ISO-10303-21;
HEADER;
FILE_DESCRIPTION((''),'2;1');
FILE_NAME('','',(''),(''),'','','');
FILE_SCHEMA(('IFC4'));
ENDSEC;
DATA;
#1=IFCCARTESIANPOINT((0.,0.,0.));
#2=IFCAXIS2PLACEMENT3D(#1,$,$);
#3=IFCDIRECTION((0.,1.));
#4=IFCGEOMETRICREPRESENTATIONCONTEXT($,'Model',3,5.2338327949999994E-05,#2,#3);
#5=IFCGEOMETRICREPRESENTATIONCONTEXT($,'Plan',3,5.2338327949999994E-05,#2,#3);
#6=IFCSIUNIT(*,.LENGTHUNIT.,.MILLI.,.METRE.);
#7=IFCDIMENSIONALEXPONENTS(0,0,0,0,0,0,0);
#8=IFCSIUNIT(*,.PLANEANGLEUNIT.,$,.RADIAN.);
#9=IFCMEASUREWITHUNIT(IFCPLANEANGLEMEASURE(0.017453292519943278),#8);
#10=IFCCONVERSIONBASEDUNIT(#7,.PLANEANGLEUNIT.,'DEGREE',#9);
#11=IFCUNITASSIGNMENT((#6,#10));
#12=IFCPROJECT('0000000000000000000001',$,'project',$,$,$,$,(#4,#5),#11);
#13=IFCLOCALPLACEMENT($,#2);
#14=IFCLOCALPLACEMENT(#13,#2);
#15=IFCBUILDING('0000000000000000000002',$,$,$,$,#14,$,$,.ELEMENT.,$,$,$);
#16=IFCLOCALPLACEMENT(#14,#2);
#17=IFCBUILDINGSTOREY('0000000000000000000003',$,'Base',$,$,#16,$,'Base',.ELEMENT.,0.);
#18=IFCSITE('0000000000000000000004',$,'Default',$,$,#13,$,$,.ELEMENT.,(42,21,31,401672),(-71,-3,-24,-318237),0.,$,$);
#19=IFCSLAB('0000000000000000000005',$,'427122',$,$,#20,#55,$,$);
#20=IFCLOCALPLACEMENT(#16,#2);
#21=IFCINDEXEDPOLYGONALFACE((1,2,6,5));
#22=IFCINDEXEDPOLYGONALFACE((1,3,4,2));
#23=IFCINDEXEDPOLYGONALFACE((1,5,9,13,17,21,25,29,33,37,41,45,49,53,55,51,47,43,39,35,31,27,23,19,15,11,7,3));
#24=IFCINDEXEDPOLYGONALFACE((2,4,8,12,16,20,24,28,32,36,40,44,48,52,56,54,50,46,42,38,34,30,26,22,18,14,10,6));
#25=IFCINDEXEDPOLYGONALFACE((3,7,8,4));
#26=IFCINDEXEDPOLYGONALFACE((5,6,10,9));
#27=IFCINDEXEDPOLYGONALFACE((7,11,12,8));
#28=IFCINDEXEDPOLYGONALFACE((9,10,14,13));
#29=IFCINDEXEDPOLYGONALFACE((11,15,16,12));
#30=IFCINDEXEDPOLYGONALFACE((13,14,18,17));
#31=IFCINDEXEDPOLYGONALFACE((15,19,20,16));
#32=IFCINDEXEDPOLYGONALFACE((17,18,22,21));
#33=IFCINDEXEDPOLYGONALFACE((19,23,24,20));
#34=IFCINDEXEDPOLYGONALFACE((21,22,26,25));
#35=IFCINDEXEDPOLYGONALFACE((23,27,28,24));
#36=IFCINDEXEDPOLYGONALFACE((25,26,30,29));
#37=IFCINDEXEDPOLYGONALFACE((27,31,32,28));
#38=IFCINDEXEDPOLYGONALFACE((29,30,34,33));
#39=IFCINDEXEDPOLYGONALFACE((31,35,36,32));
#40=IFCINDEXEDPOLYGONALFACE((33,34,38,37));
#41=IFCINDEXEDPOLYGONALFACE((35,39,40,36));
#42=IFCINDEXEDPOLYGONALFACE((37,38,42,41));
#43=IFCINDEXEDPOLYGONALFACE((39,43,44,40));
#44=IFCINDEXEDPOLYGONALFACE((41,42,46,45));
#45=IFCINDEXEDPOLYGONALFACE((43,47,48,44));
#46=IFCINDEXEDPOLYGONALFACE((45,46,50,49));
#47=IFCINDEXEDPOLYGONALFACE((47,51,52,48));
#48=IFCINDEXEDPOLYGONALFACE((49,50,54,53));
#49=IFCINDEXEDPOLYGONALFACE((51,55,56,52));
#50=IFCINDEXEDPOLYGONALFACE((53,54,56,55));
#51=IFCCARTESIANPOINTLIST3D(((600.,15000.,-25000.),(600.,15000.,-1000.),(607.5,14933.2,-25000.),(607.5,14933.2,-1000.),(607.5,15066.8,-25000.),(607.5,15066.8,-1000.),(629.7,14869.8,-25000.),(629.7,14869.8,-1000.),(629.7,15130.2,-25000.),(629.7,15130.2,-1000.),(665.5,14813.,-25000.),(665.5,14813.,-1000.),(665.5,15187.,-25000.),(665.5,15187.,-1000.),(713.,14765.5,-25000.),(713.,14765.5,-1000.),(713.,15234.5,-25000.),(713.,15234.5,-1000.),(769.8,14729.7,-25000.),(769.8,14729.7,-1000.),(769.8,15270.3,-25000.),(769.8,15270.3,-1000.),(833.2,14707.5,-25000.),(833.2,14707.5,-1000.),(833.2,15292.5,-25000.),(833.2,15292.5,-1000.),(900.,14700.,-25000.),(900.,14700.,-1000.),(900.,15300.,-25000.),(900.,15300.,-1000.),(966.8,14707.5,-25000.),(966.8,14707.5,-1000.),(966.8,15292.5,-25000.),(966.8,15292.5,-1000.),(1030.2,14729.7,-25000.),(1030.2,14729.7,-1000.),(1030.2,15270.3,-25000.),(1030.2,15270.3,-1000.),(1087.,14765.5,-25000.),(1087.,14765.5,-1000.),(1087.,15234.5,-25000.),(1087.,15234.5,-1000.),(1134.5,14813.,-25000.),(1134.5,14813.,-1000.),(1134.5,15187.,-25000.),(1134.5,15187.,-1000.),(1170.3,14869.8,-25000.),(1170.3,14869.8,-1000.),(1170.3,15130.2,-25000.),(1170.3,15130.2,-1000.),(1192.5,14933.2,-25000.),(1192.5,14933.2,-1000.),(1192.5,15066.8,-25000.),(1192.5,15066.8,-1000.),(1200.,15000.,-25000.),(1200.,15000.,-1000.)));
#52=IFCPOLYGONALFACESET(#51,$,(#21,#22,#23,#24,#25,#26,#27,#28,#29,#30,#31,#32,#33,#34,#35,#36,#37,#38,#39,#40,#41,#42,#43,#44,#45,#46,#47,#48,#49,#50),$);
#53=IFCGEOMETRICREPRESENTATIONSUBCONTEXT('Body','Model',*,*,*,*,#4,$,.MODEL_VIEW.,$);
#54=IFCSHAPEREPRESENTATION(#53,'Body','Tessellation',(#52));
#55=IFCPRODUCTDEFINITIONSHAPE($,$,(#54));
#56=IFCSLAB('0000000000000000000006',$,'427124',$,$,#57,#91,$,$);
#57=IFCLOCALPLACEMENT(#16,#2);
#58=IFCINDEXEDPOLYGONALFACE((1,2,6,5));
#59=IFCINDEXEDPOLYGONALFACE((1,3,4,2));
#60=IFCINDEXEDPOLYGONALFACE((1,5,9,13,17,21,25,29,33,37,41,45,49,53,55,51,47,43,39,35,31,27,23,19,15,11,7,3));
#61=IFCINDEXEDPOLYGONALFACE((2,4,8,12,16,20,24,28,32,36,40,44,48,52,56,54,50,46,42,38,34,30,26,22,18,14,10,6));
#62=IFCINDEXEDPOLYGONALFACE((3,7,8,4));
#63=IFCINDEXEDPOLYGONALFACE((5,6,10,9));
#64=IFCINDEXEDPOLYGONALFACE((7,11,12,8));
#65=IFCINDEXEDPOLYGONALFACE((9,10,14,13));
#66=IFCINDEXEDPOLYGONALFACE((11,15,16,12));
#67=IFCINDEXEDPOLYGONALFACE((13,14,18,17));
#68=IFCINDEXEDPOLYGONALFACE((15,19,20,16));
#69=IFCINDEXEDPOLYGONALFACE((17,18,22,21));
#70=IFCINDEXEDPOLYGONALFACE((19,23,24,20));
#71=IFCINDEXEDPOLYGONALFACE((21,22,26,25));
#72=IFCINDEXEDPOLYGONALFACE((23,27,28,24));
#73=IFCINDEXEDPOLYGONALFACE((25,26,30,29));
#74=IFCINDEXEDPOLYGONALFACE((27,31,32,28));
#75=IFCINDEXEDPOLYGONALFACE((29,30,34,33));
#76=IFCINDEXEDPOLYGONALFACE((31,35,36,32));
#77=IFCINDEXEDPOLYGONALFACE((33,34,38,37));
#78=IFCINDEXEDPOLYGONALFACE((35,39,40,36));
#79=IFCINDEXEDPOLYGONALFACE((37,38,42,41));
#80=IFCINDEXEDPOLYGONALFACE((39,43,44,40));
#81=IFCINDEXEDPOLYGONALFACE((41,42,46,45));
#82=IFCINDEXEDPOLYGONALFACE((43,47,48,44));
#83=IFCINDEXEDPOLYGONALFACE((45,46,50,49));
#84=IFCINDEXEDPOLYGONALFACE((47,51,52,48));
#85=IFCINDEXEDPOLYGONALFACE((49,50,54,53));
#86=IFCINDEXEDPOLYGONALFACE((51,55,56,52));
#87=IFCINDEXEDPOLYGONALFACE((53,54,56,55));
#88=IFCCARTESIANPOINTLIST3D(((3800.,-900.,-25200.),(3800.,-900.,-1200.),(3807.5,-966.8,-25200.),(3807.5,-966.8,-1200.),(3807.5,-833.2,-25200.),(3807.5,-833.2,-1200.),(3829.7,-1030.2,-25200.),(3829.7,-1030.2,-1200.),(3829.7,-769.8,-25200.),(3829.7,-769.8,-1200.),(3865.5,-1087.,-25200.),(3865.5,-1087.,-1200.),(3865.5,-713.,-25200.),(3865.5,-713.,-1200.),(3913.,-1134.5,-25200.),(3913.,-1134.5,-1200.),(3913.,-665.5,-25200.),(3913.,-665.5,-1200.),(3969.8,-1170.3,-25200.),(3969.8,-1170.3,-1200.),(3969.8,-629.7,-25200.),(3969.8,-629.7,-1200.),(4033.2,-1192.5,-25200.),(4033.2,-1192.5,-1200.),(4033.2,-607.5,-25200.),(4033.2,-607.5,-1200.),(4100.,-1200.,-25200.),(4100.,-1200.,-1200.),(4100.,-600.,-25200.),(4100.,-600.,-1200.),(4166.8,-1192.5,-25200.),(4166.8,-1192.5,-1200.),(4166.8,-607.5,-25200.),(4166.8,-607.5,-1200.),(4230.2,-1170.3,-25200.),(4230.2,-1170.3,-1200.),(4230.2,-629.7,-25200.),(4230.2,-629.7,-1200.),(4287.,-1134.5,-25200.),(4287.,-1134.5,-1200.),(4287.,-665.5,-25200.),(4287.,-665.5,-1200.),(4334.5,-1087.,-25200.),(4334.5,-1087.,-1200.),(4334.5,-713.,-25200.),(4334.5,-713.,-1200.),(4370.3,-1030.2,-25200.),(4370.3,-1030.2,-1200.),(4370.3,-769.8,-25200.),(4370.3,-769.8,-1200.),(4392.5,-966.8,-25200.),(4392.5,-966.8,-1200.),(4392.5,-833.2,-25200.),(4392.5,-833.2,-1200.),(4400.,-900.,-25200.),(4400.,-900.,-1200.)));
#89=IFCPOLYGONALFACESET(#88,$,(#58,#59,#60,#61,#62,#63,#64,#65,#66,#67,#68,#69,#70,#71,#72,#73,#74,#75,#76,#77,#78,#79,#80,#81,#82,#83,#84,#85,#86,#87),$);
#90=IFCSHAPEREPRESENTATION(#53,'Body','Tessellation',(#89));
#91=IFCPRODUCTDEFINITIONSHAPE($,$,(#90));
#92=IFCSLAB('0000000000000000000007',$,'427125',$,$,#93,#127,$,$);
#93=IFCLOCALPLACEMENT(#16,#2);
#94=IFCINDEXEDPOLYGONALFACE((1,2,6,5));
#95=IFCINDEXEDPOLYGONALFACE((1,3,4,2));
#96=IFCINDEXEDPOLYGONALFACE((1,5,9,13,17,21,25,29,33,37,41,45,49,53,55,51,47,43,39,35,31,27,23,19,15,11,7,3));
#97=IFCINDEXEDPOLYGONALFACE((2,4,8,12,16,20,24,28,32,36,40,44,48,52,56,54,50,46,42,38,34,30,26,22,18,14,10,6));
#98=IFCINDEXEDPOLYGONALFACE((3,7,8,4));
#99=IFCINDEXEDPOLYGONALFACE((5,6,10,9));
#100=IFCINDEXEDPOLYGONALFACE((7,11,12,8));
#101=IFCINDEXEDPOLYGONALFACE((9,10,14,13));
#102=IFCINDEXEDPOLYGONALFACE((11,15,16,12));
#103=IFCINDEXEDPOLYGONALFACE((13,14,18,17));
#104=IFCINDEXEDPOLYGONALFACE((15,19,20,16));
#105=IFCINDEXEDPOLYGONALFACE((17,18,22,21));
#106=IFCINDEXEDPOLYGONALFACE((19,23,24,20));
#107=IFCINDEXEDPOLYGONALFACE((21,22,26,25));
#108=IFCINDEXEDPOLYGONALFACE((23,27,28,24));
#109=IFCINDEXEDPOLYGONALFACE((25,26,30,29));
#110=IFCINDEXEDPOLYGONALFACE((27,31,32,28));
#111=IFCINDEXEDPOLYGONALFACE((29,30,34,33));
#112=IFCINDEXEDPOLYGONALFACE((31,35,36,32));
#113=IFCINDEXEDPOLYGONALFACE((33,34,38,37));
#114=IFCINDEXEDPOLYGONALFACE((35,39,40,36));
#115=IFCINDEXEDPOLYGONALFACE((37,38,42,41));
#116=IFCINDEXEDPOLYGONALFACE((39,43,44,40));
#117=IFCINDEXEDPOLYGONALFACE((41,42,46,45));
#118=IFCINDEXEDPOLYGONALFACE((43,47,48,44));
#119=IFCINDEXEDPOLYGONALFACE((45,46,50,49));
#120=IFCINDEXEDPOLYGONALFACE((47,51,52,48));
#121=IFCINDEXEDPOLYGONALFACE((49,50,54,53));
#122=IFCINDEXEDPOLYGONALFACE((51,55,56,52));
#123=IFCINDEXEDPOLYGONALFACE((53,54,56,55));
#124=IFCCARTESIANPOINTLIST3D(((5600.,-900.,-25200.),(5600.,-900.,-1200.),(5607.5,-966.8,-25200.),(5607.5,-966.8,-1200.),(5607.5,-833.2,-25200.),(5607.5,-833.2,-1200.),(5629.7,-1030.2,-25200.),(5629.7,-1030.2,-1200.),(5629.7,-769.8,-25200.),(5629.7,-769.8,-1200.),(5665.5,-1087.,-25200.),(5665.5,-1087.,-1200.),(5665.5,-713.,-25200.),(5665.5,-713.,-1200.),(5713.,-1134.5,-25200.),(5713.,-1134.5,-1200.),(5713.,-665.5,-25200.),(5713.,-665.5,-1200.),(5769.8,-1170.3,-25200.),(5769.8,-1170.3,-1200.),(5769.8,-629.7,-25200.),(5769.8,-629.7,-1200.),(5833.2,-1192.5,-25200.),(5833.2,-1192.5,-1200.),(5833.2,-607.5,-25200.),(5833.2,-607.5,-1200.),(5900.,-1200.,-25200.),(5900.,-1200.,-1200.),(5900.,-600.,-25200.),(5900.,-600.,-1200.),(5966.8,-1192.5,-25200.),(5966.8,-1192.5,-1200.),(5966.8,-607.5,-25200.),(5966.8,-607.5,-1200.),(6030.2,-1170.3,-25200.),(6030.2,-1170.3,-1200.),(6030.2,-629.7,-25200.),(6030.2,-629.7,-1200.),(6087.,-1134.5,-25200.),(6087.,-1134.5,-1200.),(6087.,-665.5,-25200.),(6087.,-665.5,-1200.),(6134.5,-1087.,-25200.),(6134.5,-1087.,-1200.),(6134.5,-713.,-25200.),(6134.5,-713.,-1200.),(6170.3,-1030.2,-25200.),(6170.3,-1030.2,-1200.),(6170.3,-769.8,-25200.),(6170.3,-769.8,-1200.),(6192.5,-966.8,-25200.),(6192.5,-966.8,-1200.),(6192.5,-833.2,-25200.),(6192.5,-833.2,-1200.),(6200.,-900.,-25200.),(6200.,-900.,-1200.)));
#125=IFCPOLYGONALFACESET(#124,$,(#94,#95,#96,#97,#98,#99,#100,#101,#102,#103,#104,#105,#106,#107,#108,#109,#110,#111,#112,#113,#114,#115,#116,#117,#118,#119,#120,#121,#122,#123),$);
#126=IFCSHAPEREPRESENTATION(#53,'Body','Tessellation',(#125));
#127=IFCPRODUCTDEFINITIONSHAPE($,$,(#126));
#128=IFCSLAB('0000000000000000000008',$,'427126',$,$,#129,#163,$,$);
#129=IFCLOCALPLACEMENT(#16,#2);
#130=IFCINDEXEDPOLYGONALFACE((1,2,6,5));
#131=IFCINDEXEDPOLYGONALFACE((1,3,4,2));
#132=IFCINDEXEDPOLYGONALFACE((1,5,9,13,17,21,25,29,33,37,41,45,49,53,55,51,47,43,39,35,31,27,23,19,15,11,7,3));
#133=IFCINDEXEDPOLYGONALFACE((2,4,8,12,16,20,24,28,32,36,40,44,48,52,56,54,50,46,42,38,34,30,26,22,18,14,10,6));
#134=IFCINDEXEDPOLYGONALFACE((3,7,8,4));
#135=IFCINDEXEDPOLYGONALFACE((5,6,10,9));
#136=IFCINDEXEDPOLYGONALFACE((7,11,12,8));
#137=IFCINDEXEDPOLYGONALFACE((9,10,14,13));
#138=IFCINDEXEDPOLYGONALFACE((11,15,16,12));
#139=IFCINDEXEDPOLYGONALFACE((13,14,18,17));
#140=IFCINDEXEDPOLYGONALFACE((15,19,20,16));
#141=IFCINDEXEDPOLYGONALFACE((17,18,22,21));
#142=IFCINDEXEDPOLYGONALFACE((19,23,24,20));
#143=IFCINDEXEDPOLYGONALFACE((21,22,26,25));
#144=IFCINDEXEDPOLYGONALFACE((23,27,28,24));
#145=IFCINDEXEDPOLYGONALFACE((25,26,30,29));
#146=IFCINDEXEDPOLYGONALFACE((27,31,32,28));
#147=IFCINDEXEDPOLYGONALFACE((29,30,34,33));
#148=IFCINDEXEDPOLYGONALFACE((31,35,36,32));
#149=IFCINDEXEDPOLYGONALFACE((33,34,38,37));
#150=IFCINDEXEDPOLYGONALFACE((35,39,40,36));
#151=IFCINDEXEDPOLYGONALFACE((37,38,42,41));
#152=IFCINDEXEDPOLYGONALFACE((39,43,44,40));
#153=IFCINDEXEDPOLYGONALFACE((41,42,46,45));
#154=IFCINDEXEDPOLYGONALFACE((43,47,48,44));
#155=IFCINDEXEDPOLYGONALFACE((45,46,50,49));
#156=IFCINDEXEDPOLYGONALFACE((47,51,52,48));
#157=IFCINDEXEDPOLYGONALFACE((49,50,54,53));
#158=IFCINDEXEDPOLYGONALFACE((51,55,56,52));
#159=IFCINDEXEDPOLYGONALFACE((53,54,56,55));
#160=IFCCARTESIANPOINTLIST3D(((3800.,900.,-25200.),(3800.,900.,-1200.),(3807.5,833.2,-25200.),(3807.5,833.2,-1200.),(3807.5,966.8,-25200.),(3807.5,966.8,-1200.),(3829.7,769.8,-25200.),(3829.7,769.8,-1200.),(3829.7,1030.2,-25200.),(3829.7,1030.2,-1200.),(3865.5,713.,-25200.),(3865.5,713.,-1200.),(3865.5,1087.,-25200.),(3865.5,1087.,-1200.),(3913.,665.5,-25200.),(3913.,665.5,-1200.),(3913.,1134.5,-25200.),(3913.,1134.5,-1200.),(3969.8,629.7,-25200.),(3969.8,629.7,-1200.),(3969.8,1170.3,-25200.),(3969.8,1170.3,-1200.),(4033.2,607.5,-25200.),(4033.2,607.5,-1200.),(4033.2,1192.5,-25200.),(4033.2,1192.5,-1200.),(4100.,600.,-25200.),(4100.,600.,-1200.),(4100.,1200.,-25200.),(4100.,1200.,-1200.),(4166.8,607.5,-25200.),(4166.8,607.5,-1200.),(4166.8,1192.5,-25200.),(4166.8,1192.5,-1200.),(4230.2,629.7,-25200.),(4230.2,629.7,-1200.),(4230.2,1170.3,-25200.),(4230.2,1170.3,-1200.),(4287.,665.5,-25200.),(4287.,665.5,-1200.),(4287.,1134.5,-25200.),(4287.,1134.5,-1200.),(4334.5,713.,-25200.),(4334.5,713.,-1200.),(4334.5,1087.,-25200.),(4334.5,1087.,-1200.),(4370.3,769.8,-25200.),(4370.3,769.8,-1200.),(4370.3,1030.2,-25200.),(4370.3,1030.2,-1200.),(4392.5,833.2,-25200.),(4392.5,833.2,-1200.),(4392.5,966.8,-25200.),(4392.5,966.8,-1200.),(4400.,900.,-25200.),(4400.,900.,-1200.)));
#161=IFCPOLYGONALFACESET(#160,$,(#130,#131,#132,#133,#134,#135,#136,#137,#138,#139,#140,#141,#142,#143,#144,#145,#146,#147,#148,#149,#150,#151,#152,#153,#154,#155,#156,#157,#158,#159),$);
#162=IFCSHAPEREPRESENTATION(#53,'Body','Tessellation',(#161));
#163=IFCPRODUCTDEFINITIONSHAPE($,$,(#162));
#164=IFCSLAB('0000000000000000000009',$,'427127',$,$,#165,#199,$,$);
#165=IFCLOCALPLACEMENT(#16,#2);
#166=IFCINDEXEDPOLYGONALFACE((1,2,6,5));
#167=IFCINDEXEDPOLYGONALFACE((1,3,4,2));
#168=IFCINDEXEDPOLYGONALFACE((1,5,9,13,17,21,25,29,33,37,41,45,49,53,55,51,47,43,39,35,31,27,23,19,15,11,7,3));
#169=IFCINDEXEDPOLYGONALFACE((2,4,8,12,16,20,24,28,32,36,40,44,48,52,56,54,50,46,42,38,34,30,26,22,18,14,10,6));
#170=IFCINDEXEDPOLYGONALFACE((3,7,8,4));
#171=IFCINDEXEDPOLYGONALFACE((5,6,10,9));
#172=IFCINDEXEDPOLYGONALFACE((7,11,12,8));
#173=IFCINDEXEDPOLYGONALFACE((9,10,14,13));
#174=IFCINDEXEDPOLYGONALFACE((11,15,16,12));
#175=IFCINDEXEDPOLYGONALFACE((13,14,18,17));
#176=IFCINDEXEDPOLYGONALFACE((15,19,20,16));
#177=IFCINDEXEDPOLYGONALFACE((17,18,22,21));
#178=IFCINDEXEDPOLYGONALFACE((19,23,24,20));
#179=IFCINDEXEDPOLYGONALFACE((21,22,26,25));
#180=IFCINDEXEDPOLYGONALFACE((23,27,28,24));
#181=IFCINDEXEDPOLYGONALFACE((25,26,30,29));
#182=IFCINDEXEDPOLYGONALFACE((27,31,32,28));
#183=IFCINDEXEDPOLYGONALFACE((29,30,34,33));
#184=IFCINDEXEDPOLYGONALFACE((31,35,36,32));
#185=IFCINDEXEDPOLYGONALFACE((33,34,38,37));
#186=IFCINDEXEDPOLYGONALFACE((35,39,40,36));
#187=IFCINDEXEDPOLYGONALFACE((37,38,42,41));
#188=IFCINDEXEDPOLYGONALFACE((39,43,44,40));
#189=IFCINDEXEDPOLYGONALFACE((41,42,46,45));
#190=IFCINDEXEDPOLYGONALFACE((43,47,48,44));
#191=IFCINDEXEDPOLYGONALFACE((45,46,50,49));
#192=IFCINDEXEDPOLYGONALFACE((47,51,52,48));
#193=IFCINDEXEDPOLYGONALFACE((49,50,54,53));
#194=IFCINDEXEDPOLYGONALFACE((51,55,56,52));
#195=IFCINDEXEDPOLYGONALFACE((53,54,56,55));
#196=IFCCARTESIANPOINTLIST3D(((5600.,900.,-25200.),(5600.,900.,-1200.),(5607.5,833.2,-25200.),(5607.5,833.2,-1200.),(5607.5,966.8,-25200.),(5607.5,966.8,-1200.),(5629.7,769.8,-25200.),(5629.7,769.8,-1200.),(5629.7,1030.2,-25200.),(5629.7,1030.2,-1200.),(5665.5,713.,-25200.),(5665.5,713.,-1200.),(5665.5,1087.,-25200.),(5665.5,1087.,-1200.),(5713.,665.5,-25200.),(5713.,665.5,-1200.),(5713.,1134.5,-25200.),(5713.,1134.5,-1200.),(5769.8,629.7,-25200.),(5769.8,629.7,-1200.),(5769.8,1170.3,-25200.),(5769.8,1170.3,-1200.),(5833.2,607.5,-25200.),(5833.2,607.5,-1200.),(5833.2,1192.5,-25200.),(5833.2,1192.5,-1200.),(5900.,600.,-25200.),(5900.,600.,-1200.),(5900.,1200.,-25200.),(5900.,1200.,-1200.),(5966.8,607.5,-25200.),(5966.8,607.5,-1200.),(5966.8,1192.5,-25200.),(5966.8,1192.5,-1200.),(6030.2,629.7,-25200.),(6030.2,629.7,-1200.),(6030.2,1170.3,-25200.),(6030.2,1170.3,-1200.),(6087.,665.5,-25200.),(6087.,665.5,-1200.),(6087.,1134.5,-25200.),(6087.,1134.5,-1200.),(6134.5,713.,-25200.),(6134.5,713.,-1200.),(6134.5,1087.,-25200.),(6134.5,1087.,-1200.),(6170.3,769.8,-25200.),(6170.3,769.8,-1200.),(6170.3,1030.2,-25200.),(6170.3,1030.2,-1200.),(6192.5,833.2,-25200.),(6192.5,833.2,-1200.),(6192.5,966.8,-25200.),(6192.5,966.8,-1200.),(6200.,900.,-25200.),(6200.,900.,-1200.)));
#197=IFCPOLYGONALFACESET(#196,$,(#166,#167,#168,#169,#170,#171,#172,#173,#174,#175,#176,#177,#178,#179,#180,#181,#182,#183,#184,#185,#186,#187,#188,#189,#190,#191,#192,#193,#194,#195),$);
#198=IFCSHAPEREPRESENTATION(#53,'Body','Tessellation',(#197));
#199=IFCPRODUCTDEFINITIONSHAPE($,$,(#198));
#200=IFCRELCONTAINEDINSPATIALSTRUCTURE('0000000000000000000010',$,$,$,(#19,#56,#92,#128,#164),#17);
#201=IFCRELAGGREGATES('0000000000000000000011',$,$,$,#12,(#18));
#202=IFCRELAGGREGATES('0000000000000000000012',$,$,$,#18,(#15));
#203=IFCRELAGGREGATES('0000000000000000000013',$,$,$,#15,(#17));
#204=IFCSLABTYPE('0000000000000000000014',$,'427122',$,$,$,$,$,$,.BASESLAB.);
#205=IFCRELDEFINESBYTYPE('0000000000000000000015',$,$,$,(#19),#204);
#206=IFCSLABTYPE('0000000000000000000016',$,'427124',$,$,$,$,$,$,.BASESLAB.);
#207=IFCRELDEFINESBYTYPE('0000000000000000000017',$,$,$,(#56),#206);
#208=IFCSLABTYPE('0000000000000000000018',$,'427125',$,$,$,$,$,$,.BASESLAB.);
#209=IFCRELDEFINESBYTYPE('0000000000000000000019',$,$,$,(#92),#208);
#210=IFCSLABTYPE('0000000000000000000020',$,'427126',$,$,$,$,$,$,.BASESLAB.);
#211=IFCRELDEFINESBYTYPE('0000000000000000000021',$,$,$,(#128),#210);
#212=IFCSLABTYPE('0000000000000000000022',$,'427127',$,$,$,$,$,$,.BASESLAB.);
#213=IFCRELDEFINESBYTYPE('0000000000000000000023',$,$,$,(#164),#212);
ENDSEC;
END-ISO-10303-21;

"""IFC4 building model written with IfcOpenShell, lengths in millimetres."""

from ifc_helpers import new_model, entity, si_unit, converted_unit, direction, frame, origin, place, context, subcontext, project, spatial, arc, indexed_curve, outline, extrude, type_object, element, save


model = new_model("IFC4")

# Units and contexts
model_context = context("Model", 3, precision=5.2338327949999994e-05, world=origin(), true_north=direction((0.0, 1.0)))
plan_context = context("Plan", 3, precision=5.2338327949999994e-05, world=origin(), true_north=direction((0.0, 1.0)))
body_context = subcontext(model_context, "Body", "Model", "MODEL_VIEW")
ifc_project = project(units=[si_unit("LENGTHUNIT", "METRE", prefix="MILLI"), converted_unit("PLANEANGLEUNIT", "DEGREE", entity("IfcPlaneAngleMeasure", 0.017453292519943278), si_unit("PLANEANGLEUNIT", "RADIAN"), dimensions=[0, 0, 0, 0, 0, 0, 0])], contexts=[model_context, plan_context])

# Site, building, storey
site_placement = place(None, origin())
site = spatial("IfcSite", under=ifc_project, at=site_placement, Name="Default", CompositionType="ELEMENT", RefLatitude=(42, 21, 31, 401672), RefLongitude=(-71, -3, -24, -318237), RefElevation=0.0)
building_placement = place(site_placement, origin())
building = spatial("IfcBuilding", under=site, at=building_placement, CompositionType="ELEMENT")
storey_placement = place(building_placement, origin())
storey = spatial("IfcBuildingStorey", under=building, at=storey_placement, Name="Base", LongName="Base", CompositionType="ELEMENT", Elevation=0.0)

# Slabs
slab_type_1 = type_object("IfcSlabType", Name="427122", PredefinedType="BASESLAB")
slab_1_placement = place(storey_placement, origin())
element("IfcSlab", 1, at=slab_1_placement, inside=storey, type_object=slab_type_1, Name="427122", context=body_context, shape_type="SweptSolid", body=[
    extrude(outline(indexed_curve([(300.0, 0.0), (0.0, 300.0), (-300.0, 0.0), (0.0, -300.0)], segments=[arc(1, 2, 3), arc(3, 4, 1)], self_intersect=False)), frame((900.0, 15000.0, -25000.0)), (0.0, 0.0, 1.0), 24000.0),
])
slab_type_2 = type_object("IfcSlabType", Name="427124", PredefinedType="BASESLAB")
slab_2_placement = place(storey_placement, origin())
element("IfcSlab", 2, at=slab_2_placement, inside=storey, type_object=slab_type_2, Name="427124", context=body_context, shape_type="SweptSolid", body=[
    extrude(outline(indexed_curve([(300.0, 0.0), (0.0, 300.0), (-300.0, 0.0), (0.0, -300.0)], segments=[arc(1, 2, 3), arc(3, 4, 1)], self_intersect=False)), frame((4100.0, -900.0, -25200.0)), (0.0, 0.0, 1.0), 24000.0),
])
slab_type_3 = type_object("IfcSlabType", Name="427125", PredefinedType="BASESLAB")
slab_3_placement = place(storey_placement, origin())
element("IfcSlab", 3, at=slab_3_placement, inside=storey, type_object=slab_type_3, Name="427125", context=body_context, shape_type="SweptSolid", body=[
    extrude(outline(indexed_curve([(300.0, 0.0), (0.0, 300.0), (-300.0, 0.0), (0.0, -300.0)], segments=[arc(1, 2, 3), arc(3, 4, 1)], self_intersect=False)), frame((5900.0, -900.0, -25200.0)), (0.0, 0.0, 1.0), 24000.0),
])
slab_type_4 = type_object("IfcSlabType", Name="427126", PredefinedType="BASESLAB")
slab_4_placement = place(storey_placement, origin())
element("IfcSlab", 4, at=slab_4_placement, inside=storey, type_object=slab_type_4, Name="427126", context=body_context, shape_type="SweptSolid", body=[
    extrude(outline(indexed_curve([(300.0, 0.0), (0.0, 300.0), (-300.0, 0.0), (0.0, -300.0)], segments=[arc(1, 2, 3), arc(3, 4, 1)], self_intersect=False)), frame((4100.0, 900.0, -25200.0)), (0.0, 0.0, 1.0), 24000.0),
])
slab_type_5 = type_object("IfcSlabType", Name="427127", PredefinedType="BASESLAB")
slab_5_placement = place(storey_placement, origin())
element("IfcSlab", 5, at=slab_5_placement, inside=storey, type_object=slab_type_5, Name="427127", context=body_context, shape_type="SweptSolid", body=[
    extrude(outline(indexed_curve([(300.0, 0.0), (0.0, 300.0), (-300.0, 0.0), (0.0, -300.0)], segments=[arc(1, 2, 3), arc(3, 4, 1)], self_intersect=False)), frame((5900.0, 900.0, -25200.0)), (0.0, 0.0, 1.0), 24000.0),
])

save(model, "model.ifc")
